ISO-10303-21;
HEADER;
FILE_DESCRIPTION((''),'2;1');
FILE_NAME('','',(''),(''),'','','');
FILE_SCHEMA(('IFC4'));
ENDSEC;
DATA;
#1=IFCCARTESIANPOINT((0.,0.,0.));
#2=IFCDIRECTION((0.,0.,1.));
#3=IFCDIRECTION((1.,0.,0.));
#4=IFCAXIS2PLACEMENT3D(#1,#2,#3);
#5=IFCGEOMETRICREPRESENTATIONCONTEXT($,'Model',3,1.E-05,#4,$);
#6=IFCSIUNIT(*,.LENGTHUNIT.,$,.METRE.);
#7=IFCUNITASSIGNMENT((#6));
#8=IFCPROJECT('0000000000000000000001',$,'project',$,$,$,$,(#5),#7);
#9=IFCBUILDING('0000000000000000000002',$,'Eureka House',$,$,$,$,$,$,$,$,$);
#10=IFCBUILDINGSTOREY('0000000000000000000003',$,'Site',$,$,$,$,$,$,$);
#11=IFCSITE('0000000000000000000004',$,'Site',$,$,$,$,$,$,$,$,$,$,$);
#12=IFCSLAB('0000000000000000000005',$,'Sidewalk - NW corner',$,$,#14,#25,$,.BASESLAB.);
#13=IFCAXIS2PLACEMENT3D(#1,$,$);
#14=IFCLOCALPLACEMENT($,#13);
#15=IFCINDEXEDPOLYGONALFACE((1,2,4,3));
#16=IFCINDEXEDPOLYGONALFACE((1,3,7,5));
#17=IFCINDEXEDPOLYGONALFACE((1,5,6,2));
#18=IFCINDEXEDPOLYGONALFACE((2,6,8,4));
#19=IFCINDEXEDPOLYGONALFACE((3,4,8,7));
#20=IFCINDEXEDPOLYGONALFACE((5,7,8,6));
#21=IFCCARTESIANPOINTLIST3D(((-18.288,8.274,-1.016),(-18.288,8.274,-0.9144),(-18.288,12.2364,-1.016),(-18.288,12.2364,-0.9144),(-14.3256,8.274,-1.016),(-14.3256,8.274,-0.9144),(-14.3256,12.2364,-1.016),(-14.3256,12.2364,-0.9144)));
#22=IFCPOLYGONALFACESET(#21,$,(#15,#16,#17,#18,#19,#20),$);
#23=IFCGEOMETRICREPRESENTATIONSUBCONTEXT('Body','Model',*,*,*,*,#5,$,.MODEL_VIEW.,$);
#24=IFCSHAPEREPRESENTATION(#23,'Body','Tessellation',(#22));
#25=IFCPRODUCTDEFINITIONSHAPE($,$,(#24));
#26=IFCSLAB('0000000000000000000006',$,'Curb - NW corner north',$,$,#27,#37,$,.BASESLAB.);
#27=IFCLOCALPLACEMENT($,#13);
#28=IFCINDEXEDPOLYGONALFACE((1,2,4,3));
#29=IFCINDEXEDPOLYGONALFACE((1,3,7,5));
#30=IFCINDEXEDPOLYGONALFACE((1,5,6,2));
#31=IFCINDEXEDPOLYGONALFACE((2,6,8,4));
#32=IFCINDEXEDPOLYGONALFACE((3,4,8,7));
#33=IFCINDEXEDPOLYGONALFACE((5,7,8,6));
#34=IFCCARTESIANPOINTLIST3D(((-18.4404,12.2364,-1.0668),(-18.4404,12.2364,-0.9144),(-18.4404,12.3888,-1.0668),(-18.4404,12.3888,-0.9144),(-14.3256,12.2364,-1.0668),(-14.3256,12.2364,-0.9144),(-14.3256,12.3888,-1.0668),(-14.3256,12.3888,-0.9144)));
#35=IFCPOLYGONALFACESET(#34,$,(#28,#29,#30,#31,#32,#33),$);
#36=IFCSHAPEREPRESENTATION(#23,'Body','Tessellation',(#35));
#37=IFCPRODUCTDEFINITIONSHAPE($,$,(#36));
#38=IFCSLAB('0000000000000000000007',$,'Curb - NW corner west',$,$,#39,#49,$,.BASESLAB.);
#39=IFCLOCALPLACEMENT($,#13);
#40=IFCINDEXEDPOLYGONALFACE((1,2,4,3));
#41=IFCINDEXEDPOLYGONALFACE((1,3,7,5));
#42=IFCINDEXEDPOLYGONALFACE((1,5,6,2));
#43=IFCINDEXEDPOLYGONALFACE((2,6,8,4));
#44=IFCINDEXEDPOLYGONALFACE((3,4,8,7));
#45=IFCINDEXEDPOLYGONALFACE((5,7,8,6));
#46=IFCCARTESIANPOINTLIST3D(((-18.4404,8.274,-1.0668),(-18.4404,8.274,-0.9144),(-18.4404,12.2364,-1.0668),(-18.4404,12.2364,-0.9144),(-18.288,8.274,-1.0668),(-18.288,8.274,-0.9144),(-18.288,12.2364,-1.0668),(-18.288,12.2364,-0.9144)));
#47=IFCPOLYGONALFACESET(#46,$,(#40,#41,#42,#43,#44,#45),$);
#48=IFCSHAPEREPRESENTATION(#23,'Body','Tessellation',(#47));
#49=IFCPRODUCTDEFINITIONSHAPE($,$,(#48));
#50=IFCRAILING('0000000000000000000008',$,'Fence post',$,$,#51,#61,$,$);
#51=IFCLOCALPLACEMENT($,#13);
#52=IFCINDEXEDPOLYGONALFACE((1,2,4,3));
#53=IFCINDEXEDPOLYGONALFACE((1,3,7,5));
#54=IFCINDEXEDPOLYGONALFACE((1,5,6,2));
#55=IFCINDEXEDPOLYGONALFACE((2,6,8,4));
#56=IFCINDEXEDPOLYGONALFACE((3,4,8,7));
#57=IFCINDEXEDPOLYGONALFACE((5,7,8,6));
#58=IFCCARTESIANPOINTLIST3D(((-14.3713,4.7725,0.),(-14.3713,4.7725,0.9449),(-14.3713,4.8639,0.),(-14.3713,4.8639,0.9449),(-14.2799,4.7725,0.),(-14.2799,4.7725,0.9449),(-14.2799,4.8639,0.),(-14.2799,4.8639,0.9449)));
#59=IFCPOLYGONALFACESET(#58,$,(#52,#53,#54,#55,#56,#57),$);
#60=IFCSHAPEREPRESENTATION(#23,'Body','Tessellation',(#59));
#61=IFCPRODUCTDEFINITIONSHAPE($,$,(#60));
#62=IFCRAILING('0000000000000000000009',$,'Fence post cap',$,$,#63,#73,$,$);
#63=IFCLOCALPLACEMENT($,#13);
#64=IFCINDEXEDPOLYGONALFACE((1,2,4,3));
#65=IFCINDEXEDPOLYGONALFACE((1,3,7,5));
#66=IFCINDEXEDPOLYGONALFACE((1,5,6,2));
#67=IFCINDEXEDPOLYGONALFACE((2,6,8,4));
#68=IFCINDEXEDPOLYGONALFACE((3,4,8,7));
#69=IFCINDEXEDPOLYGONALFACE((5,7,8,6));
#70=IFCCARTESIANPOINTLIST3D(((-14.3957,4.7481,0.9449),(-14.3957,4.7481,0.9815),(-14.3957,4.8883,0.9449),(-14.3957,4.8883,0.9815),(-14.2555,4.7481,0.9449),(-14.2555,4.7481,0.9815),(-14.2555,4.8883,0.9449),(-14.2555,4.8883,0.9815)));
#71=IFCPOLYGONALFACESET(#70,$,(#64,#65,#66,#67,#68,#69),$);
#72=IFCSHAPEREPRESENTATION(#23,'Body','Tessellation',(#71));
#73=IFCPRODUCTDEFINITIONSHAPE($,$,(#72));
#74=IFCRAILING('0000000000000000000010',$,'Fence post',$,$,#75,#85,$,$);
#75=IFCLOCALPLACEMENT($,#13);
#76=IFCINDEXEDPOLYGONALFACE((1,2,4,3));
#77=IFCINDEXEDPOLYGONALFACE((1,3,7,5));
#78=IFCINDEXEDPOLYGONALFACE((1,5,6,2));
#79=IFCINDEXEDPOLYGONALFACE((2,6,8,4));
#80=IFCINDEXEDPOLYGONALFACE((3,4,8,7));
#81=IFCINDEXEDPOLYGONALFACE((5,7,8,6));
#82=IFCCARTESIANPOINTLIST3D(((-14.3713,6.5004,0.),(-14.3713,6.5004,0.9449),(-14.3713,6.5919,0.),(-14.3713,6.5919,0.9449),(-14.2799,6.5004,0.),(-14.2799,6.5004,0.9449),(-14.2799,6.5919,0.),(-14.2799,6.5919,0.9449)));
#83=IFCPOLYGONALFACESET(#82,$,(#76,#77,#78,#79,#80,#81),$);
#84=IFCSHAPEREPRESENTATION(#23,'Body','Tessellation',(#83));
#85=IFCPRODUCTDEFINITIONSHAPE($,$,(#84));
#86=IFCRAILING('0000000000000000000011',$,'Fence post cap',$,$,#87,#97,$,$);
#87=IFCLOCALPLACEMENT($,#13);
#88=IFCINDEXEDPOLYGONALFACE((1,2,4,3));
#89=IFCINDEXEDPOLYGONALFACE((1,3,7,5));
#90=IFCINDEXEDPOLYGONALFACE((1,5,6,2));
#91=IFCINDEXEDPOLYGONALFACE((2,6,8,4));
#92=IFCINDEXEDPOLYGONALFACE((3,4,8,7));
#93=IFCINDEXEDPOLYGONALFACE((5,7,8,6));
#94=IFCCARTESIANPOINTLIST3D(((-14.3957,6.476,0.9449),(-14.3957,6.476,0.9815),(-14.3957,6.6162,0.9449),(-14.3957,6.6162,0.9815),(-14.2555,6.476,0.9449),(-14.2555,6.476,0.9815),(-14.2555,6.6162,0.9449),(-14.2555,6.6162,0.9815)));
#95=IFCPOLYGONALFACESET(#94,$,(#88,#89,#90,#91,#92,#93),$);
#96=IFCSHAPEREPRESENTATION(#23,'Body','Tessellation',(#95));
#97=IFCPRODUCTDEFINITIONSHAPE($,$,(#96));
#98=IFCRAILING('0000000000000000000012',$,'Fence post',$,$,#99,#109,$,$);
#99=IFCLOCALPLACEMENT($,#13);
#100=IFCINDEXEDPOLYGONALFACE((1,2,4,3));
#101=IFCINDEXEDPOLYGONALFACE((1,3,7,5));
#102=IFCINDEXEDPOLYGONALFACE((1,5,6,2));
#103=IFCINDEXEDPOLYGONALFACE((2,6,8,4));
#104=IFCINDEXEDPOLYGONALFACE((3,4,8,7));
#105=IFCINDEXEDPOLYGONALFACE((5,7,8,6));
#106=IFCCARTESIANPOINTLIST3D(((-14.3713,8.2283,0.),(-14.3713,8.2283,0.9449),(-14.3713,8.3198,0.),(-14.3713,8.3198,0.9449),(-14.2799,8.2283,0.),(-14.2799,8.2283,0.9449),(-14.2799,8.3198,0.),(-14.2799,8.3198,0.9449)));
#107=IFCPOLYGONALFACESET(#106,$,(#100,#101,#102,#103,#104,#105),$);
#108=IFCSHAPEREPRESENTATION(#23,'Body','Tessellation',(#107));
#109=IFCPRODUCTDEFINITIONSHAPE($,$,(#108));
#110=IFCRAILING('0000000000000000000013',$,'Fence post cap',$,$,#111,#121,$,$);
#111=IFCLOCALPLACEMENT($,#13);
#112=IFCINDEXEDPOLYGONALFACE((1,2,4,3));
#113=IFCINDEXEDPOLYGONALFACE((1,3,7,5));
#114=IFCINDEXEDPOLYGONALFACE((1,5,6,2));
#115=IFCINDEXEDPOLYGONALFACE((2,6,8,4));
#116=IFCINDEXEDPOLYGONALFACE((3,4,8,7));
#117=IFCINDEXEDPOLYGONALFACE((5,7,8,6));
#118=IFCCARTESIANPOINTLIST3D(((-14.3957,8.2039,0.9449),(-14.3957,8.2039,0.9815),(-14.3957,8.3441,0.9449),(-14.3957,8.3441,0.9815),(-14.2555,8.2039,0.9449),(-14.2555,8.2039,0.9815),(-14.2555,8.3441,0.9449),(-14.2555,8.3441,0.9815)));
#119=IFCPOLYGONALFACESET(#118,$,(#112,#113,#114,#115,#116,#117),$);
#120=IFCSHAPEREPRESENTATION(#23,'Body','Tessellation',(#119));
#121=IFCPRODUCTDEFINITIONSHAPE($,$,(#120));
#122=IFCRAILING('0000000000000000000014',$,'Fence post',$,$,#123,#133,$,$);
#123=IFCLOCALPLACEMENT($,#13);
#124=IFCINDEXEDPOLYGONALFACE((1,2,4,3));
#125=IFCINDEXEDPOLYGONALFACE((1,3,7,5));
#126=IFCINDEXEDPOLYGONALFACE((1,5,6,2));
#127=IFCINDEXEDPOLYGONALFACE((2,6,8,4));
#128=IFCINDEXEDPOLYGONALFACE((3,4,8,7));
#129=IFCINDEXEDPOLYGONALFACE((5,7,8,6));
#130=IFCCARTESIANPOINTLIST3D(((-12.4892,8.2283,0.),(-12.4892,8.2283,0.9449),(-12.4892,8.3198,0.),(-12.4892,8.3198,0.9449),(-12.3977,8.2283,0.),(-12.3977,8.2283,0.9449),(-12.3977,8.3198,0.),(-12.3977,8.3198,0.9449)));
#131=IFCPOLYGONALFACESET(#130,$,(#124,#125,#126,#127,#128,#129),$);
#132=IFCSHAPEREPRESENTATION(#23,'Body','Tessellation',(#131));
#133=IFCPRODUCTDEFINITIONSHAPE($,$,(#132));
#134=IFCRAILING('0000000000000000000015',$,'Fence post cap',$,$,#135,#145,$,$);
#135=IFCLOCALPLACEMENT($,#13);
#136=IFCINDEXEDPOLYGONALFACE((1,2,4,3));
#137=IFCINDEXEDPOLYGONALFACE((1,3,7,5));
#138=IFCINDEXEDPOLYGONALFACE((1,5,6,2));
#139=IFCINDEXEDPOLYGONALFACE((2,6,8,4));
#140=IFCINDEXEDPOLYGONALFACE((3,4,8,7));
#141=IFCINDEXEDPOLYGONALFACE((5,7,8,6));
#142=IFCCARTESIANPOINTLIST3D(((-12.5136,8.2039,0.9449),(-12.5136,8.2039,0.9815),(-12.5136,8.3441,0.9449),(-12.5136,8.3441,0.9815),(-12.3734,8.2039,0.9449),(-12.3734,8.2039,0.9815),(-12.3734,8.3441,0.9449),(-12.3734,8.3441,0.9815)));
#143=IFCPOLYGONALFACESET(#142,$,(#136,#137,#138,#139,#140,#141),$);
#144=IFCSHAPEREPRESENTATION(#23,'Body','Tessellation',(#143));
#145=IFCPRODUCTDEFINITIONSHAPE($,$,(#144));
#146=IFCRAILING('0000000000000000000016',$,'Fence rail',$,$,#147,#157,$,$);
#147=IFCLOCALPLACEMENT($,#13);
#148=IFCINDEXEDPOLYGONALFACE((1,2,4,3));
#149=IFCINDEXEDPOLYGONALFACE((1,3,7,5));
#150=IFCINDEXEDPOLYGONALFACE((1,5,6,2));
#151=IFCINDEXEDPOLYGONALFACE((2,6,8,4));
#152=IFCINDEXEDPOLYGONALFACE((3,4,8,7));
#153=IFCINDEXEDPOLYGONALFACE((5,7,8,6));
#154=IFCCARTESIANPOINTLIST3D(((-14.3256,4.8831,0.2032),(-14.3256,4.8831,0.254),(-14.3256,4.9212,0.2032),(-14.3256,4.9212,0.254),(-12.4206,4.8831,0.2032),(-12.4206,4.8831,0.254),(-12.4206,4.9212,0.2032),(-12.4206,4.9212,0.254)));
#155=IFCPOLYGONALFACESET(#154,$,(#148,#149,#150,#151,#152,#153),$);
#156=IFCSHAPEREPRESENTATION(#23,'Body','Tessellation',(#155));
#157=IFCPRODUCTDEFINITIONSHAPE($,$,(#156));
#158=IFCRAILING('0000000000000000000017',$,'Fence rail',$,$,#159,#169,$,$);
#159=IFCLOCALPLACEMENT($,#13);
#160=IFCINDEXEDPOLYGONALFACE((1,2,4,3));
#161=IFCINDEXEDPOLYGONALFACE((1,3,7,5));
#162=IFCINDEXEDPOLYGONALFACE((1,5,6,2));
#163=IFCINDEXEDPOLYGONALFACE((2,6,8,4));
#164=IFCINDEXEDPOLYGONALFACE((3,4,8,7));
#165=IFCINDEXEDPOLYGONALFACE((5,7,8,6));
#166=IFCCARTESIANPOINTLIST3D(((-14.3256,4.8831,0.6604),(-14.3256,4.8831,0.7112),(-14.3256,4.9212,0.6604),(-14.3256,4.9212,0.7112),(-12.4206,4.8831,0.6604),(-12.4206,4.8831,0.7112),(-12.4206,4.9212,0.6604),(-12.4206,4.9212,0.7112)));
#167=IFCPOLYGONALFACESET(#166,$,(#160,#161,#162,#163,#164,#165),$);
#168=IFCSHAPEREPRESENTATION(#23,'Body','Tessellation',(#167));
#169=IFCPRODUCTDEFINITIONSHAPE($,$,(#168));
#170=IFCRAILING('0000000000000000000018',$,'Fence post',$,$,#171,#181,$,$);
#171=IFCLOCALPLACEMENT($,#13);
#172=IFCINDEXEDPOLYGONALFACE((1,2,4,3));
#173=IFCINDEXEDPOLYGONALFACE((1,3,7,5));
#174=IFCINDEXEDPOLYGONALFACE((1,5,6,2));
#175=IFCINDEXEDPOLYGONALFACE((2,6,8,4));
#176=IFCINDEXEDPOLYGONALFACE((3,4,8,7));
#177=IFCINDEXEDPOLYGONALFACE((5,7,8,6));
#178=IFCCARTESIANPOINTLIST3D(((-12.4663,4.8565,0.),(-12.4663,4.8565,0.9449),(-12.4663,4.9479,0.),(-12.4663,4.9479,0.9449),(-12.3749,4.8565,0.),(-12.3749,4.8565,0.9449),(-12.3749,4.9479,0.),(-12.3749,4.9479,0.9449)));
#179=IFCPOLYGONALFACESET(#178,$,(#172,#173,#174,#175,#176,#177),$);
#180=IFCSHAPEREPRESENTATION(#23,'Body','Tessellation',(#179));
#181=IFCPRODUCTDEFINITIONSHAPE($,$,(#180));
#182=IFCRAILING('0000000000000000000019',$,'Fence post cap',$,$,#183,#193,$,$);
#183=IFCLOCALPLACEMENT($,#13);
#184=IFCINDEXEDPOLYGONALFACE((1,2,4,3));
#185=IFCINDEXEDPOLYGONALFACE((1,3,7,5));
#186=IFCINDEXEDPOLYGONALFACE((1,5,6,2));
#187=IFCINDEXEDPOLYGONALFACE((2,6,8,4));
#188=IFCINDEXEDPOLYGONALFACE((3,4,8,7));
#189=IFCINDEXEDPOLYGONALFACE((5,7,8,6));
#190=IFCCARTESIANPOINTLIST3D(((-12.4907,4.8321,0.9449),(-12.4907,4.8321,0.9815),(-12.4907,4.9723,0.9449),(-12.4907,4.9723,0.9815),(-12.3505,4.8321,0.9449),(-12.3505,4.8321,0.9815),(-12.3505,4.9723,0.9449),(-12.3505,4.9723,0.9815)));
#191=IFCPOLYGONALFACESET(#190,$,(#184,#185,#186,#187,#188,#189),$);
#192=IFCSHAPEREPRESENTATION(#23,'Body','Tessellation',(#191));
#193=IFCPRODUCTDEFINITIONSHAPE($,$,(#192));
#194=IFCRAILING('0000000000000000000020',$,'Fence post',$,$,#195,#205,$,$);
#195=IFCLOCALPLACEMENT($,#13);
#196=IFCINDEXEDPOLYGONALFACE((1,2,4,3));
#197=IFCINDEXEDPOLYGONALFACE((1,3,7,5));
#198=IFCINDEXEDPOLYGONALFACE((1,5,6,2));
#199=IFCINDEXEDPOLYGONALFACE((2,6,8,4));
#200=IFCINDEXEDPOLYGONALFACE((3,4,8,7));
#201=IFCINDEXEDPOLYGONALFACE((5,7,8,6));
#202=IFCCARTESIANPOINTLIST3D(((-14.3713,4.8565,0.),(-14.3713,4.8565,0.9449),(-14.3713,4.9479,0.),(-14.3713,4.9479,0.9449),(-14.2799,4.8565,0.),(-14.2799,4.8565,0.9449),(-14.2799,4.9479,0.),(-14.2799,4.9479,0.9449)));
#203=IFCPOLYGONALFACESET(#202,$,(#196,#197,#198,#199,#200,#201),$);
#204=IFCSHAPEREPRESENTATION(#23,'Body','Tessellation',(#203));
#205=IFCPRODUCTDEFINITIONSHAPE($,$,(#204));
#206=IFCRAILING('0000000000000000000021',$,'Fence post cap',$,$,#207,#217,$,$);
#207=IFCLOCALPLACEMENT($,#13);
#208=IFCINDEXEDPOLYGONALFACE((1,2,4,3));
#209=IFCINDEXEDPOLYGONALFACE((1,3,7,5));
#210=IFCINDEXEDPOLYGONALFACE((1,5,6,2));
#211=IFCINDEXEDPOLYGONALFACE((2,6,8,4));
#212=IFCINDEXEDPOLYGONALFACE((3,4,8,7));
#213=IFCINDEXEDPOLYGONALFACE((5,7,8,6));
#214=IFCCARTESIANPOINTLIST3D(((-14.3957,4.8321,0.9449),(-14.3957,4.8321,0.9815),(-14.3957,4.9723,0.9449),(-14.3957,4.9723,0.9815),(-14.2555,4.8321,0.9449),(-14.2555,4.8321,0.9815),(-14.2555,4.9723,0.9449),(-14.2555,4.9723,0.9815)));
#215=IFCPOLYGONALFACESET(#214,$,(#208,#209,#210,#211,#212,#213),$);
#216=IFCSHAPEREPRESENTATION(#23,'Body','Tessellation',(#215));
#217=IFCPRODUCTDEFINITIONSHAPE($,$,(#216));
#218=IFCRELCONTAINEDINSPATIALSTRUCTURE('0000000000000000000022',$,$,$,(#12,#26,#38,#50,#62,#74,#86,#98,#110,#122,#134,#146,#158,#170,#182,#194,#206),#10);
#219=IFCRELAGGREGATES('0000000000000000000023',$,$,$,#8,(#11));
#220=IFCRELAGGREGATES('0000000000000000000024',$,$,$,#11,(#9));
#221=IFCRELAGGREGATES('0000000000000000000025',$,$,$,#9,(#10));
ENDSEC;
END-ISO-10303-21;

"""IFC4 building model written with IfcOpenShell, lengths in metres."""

from ifc_helpers import new_model, si_unit, frame, origin, origin_with_axes, origin_2d, place, context, subcontext, project, spatial, rectangle, extrude, element, save


model = new_model("IFC4")

# Units and contexts
model_context = context("Model", 3, precision=1e-05, world=origin_with_axes())
body_context = subcontext(model_context, "Body", "Model", "MODEL_VIEW")
ifc_project = project(units=[si_unit("LENGTHUNIT", "METRE")], contexts=[model_context])

# Site, building, storey
site = spatial("IfcSite", under=ifc_project, Name="Site")
building = spatial("IfcBuilding", under=site, Name="Eureka House")
storey = spatial("IfcBuildingStorey", under=building, Name="Site")

# Slabs
slab_1_placement = place(None, frame((-16.3068, 10.2552, -1.016), z_axis=(0.0, 0.0, 1.0), x_axis=(1.0, 0.0, 0.0)))
element("IfcSlab", 1, at=slab_1_placement, inside=storey, Name="Sidewalk - NW corner", PredefinedType="BASESLAB", context=body_context, shape_type="SweptSolid", body=[
    extrude(rectangle(XDim=3.9624, YDim=3.9624, at=origin_2d()), origin(), (0.0, 0.0, 1.0), 0.1016),
])
slab_2_placement = place(None, frame((-16.383, 12.3126, -1.0668), z_axis=(0.0, 0.0, 1.0), x_axis=(1.0, 0.0, 0.0)))
element("IfcSlab", 2, at=slab_2_placement, inside=storey, Name="Curb - NW corner north", PredefinedType="BASESLAB", context=body_context, shape_type="SweptSolid", body=[
    extrude(rectangle(XDim=4.1148, YDim=0.1524, at=origin_2d()), origin(), (0.0, 0.0, 1.0), 0.1524),
])
slab_3_placement = place(None, frame((-18.3642, 10.2552, -1.0668), z_axis=(0.0, 0.0, 1.0), x_axis=(1.0, 0.0, 0.0)))
element("IfcSlab", 3, at=slab_3_placement, inside=storey, Name="Curb - NW corner west", PredefinedType="BASESLAB", context=body_context, shape_type="SweptSolid", body=[
    extrude(rectangle(XDim=0.1524, YDim=3.9624, at=origin_2d()), origin(), (0.0, 0.0, 1.0), 0.1524),
])

# Railings
railing_1_placement = place(None, frame((-14.3256, 4.8182, 0.0), z_axis=(0.0, 0.0, 1.0), x_axis=(1.0, 0.0, 0.0)))
element("IfcRailing", 4, at=railing_1_placement, inside=storey, Name="Fence post", context=body_context, shape_type="SweptSolid", body=[
    extrude(rectangle(XDim=0.0914, YDim=0.0914, at=origin_2d()), origin(), (0.0, 0.0, 1.0), 0.9449),
])
railing_2_placement = place(None, frame((-14.3256, 4.8182, 0.9449), z_axis=(0.0, 0.0, 1.0), x_axis=(1.0, 0.0, 0.0)))
element("IfcRailing", 5, at=railing_2_placement, inside=storey, Name="Fence post cap", context=body_context, shape_type="SweptSolid", body=[
    extrude(rectangle(XDim=0.1402, YDim=0.1402, at=origin_2d()), origin(), (0.0, 0.0, 1.0), 0.0366),
])
railing_3_placement = place(None, frame((-14.3256, 6.5461, 0.0), z_axis=(0.0, 0.0, 1.0), x_axis=(1.0, 0.0, 0.0)))
element("IfcRailing", 6, at=railing_3_placement, inside=storey, Name="Fence post", context=body_context, shape_type="SweptSolid", body=[
    extrude(rectangle(XDim=0.0914, YDim=0.0914, at=origin_2d()), origin(), (0.0, 0.0, 1.0), 0.9449),
])
railing_4_placement = place(None, frame((-14.3256, 6.5461, 0.9449), z_axis=(0.0, 0.0, 1.0), x_axis=(1.0, 0.0, 0.0)))
element("IfcRailing", 7, at=railing_4_placement, inside=storey, Name="Fence post cap", context=body_context, shape_type="SweptSolid", body=[
    extrude(rectangle(XDim=0.1402, YDim=0.1402, at=origin_2d()), origin(), (0.0, 0.0, 1.0), 0.0366),
])
railing_5_placement = place(None, frame((-14.3256, 8.274, 0.0), z_axis=(0.0, 0.0, 1.0), x_axis=(1.0, 0.0, 0.0)))
element("IfcRailing", 8, at=railing_5_placement, inside=storey, Name="Fence post", context=body_context, shape_type="SweptSolid", body=[
    extrude(rectangle(XDim=0.0914, YDim=0.0914, at=origin_2d()), origin(), (0.0, 0.0, 1.0), 0.9449),
])
railing_6_placement = place(None, frame((-14.3256, 8.274, 0.9449), z_axis=(0.0, 0.0, 1.0), x_axis=(1.0, 0.0, 0.0)))
element("IfcRailing", 9, at=railing_6_placement, inside=storey, Name="Fence post cap", context=body_context, shape_type="SweptSolid", body=[
    extrude(rectangle(XDim=0.1402, YDim=0.1402, at=origin_2d()), origin(), (0.0, 0.0, 1.0), 0.0366),
])
railing_7_placement = place(None, frame((-12.4435, 8.274, 0.0), z_axis=(0.0, 0.0, 1.0), x_axis=(1.0, 0.0, 0.0)))
element("IfcRailing", 10, at=railing_7_placement, inside=storey, Name="Fence post", context=body_context, shape_type="SweptSolid", body=[
    extrude(rectangle(XDim=0.0914, YDim=0.0914, at=origin_2d()), origin(), (0.0, 0.0, 1.0), 0.9449),
])
railing_8_placement = place(None, frame((-12.4435, 8.274, 0.9449), z_axis=(0.0, 0.0, 1.0), x_axis=(1.0, 0.0, 0.0)))
element("IfcRailing", 11, at=railing_8_placement, inside=storey, Name="Fence post cap", context=body_context, shape_type="SweptSolid", body=[
    extrude(rectangle(XDim=0.1402, YDim=0.1402, at=origin_2d()), origin(), (0.0, 0.0, 1.0), 0.0366),
])
for number, where, z_axis, x_axis, name in (
    (12, (-13.3731, 4.9022, 0.2032), (0.0, 0.0, 1.0), (1.0, 0.0, 0.0), "Fence rail"),
    (13, (-13.3731, 4.9022, 0.6604), (0.0, 0.0, 1.0), (1.0, 0.0, 0.0), "Fence rail"),
):
    element("IfcRailing", number, at=place(None, frame(where, z_axis=z_axis, x_axis=x_axis)), inside=storey, Name=name, context=body_context, shape_type="SweptSolid", body=[
        extrude(rectangle(XDim=1.905, YDim=0.0381, at=origin_2d()), origin(), (0.0, 0.0, 1.0), 0.0508),
    ])
railing_9_placement = place(None, frame((-12.4206, 4.9022, 0.0), z_axis=(0.0, 0.0, 1.0), x_axis=(1.0, 0.0, 0.0)))
element("IfcRailing", 14, at=railing_9_placement, inside=storey, Name="Fence post", context=body_context, shape_type="SweptSolid", body=[
    extrude(rectangle(XDim=0.0914, YDim=0.0914, at=origin_2d()), origin(), (0.0, 0.0, 1.0), 0.9449),
])
railing_10_placement = place(None, frame((-12.4206, 4.9022, 0.9449), z_axis=(0.0, 0.0, 1.0), x_axis=(1.0, 0.0, 0.0)))
element("IfcRailing", 15, at=railing_10_placement, inside=storey, Name="Fence post cap", context=body_context, shape_type="SweptSolid", body=[
    extrude(rectangle(XDim=0.1402, YDim=0.1402, at=origin_2d()), origin(), (0.0, 0.0, 1.0), 0.0366),
])
railing_11_placement = place(None, frame((-14.3256, 4.9022, 0.0), z_axis=(0.0, 0.0, 1.0), x_axis=(1.0, 0.0, 0.0)))
element("IfcRailing", 16, at=railing_11_placement, inside=storey, Name="Fence post", context=body_context, shape_type="SweptSolid", body=[
    extrude(rectangle(XDim=0.0914, YDim=0.0914, at=origin_2d()), origin(), (0.0, 0.0, 1.0), 0.9449),
])
railing_12_placement = place(None, frame((-14.3256, 4.9022, 0.9449), z_axis=(0.0, 0.0, 1.0), x_axis=(1.0, 0.0, 0.0)))
element("IfcRailing", 17, at=railing_12_placement, inside=storey, Name="Fence post cap", context=body_context, shape_type="SweptSolid", body=[
    extrude(rectangle(XDim=0.1402, YDim=0.1402, at=origin_2d()), origin(), (0.0, 0.0, 1.0), 0.0366),
])

save(model, "model.ifc")
